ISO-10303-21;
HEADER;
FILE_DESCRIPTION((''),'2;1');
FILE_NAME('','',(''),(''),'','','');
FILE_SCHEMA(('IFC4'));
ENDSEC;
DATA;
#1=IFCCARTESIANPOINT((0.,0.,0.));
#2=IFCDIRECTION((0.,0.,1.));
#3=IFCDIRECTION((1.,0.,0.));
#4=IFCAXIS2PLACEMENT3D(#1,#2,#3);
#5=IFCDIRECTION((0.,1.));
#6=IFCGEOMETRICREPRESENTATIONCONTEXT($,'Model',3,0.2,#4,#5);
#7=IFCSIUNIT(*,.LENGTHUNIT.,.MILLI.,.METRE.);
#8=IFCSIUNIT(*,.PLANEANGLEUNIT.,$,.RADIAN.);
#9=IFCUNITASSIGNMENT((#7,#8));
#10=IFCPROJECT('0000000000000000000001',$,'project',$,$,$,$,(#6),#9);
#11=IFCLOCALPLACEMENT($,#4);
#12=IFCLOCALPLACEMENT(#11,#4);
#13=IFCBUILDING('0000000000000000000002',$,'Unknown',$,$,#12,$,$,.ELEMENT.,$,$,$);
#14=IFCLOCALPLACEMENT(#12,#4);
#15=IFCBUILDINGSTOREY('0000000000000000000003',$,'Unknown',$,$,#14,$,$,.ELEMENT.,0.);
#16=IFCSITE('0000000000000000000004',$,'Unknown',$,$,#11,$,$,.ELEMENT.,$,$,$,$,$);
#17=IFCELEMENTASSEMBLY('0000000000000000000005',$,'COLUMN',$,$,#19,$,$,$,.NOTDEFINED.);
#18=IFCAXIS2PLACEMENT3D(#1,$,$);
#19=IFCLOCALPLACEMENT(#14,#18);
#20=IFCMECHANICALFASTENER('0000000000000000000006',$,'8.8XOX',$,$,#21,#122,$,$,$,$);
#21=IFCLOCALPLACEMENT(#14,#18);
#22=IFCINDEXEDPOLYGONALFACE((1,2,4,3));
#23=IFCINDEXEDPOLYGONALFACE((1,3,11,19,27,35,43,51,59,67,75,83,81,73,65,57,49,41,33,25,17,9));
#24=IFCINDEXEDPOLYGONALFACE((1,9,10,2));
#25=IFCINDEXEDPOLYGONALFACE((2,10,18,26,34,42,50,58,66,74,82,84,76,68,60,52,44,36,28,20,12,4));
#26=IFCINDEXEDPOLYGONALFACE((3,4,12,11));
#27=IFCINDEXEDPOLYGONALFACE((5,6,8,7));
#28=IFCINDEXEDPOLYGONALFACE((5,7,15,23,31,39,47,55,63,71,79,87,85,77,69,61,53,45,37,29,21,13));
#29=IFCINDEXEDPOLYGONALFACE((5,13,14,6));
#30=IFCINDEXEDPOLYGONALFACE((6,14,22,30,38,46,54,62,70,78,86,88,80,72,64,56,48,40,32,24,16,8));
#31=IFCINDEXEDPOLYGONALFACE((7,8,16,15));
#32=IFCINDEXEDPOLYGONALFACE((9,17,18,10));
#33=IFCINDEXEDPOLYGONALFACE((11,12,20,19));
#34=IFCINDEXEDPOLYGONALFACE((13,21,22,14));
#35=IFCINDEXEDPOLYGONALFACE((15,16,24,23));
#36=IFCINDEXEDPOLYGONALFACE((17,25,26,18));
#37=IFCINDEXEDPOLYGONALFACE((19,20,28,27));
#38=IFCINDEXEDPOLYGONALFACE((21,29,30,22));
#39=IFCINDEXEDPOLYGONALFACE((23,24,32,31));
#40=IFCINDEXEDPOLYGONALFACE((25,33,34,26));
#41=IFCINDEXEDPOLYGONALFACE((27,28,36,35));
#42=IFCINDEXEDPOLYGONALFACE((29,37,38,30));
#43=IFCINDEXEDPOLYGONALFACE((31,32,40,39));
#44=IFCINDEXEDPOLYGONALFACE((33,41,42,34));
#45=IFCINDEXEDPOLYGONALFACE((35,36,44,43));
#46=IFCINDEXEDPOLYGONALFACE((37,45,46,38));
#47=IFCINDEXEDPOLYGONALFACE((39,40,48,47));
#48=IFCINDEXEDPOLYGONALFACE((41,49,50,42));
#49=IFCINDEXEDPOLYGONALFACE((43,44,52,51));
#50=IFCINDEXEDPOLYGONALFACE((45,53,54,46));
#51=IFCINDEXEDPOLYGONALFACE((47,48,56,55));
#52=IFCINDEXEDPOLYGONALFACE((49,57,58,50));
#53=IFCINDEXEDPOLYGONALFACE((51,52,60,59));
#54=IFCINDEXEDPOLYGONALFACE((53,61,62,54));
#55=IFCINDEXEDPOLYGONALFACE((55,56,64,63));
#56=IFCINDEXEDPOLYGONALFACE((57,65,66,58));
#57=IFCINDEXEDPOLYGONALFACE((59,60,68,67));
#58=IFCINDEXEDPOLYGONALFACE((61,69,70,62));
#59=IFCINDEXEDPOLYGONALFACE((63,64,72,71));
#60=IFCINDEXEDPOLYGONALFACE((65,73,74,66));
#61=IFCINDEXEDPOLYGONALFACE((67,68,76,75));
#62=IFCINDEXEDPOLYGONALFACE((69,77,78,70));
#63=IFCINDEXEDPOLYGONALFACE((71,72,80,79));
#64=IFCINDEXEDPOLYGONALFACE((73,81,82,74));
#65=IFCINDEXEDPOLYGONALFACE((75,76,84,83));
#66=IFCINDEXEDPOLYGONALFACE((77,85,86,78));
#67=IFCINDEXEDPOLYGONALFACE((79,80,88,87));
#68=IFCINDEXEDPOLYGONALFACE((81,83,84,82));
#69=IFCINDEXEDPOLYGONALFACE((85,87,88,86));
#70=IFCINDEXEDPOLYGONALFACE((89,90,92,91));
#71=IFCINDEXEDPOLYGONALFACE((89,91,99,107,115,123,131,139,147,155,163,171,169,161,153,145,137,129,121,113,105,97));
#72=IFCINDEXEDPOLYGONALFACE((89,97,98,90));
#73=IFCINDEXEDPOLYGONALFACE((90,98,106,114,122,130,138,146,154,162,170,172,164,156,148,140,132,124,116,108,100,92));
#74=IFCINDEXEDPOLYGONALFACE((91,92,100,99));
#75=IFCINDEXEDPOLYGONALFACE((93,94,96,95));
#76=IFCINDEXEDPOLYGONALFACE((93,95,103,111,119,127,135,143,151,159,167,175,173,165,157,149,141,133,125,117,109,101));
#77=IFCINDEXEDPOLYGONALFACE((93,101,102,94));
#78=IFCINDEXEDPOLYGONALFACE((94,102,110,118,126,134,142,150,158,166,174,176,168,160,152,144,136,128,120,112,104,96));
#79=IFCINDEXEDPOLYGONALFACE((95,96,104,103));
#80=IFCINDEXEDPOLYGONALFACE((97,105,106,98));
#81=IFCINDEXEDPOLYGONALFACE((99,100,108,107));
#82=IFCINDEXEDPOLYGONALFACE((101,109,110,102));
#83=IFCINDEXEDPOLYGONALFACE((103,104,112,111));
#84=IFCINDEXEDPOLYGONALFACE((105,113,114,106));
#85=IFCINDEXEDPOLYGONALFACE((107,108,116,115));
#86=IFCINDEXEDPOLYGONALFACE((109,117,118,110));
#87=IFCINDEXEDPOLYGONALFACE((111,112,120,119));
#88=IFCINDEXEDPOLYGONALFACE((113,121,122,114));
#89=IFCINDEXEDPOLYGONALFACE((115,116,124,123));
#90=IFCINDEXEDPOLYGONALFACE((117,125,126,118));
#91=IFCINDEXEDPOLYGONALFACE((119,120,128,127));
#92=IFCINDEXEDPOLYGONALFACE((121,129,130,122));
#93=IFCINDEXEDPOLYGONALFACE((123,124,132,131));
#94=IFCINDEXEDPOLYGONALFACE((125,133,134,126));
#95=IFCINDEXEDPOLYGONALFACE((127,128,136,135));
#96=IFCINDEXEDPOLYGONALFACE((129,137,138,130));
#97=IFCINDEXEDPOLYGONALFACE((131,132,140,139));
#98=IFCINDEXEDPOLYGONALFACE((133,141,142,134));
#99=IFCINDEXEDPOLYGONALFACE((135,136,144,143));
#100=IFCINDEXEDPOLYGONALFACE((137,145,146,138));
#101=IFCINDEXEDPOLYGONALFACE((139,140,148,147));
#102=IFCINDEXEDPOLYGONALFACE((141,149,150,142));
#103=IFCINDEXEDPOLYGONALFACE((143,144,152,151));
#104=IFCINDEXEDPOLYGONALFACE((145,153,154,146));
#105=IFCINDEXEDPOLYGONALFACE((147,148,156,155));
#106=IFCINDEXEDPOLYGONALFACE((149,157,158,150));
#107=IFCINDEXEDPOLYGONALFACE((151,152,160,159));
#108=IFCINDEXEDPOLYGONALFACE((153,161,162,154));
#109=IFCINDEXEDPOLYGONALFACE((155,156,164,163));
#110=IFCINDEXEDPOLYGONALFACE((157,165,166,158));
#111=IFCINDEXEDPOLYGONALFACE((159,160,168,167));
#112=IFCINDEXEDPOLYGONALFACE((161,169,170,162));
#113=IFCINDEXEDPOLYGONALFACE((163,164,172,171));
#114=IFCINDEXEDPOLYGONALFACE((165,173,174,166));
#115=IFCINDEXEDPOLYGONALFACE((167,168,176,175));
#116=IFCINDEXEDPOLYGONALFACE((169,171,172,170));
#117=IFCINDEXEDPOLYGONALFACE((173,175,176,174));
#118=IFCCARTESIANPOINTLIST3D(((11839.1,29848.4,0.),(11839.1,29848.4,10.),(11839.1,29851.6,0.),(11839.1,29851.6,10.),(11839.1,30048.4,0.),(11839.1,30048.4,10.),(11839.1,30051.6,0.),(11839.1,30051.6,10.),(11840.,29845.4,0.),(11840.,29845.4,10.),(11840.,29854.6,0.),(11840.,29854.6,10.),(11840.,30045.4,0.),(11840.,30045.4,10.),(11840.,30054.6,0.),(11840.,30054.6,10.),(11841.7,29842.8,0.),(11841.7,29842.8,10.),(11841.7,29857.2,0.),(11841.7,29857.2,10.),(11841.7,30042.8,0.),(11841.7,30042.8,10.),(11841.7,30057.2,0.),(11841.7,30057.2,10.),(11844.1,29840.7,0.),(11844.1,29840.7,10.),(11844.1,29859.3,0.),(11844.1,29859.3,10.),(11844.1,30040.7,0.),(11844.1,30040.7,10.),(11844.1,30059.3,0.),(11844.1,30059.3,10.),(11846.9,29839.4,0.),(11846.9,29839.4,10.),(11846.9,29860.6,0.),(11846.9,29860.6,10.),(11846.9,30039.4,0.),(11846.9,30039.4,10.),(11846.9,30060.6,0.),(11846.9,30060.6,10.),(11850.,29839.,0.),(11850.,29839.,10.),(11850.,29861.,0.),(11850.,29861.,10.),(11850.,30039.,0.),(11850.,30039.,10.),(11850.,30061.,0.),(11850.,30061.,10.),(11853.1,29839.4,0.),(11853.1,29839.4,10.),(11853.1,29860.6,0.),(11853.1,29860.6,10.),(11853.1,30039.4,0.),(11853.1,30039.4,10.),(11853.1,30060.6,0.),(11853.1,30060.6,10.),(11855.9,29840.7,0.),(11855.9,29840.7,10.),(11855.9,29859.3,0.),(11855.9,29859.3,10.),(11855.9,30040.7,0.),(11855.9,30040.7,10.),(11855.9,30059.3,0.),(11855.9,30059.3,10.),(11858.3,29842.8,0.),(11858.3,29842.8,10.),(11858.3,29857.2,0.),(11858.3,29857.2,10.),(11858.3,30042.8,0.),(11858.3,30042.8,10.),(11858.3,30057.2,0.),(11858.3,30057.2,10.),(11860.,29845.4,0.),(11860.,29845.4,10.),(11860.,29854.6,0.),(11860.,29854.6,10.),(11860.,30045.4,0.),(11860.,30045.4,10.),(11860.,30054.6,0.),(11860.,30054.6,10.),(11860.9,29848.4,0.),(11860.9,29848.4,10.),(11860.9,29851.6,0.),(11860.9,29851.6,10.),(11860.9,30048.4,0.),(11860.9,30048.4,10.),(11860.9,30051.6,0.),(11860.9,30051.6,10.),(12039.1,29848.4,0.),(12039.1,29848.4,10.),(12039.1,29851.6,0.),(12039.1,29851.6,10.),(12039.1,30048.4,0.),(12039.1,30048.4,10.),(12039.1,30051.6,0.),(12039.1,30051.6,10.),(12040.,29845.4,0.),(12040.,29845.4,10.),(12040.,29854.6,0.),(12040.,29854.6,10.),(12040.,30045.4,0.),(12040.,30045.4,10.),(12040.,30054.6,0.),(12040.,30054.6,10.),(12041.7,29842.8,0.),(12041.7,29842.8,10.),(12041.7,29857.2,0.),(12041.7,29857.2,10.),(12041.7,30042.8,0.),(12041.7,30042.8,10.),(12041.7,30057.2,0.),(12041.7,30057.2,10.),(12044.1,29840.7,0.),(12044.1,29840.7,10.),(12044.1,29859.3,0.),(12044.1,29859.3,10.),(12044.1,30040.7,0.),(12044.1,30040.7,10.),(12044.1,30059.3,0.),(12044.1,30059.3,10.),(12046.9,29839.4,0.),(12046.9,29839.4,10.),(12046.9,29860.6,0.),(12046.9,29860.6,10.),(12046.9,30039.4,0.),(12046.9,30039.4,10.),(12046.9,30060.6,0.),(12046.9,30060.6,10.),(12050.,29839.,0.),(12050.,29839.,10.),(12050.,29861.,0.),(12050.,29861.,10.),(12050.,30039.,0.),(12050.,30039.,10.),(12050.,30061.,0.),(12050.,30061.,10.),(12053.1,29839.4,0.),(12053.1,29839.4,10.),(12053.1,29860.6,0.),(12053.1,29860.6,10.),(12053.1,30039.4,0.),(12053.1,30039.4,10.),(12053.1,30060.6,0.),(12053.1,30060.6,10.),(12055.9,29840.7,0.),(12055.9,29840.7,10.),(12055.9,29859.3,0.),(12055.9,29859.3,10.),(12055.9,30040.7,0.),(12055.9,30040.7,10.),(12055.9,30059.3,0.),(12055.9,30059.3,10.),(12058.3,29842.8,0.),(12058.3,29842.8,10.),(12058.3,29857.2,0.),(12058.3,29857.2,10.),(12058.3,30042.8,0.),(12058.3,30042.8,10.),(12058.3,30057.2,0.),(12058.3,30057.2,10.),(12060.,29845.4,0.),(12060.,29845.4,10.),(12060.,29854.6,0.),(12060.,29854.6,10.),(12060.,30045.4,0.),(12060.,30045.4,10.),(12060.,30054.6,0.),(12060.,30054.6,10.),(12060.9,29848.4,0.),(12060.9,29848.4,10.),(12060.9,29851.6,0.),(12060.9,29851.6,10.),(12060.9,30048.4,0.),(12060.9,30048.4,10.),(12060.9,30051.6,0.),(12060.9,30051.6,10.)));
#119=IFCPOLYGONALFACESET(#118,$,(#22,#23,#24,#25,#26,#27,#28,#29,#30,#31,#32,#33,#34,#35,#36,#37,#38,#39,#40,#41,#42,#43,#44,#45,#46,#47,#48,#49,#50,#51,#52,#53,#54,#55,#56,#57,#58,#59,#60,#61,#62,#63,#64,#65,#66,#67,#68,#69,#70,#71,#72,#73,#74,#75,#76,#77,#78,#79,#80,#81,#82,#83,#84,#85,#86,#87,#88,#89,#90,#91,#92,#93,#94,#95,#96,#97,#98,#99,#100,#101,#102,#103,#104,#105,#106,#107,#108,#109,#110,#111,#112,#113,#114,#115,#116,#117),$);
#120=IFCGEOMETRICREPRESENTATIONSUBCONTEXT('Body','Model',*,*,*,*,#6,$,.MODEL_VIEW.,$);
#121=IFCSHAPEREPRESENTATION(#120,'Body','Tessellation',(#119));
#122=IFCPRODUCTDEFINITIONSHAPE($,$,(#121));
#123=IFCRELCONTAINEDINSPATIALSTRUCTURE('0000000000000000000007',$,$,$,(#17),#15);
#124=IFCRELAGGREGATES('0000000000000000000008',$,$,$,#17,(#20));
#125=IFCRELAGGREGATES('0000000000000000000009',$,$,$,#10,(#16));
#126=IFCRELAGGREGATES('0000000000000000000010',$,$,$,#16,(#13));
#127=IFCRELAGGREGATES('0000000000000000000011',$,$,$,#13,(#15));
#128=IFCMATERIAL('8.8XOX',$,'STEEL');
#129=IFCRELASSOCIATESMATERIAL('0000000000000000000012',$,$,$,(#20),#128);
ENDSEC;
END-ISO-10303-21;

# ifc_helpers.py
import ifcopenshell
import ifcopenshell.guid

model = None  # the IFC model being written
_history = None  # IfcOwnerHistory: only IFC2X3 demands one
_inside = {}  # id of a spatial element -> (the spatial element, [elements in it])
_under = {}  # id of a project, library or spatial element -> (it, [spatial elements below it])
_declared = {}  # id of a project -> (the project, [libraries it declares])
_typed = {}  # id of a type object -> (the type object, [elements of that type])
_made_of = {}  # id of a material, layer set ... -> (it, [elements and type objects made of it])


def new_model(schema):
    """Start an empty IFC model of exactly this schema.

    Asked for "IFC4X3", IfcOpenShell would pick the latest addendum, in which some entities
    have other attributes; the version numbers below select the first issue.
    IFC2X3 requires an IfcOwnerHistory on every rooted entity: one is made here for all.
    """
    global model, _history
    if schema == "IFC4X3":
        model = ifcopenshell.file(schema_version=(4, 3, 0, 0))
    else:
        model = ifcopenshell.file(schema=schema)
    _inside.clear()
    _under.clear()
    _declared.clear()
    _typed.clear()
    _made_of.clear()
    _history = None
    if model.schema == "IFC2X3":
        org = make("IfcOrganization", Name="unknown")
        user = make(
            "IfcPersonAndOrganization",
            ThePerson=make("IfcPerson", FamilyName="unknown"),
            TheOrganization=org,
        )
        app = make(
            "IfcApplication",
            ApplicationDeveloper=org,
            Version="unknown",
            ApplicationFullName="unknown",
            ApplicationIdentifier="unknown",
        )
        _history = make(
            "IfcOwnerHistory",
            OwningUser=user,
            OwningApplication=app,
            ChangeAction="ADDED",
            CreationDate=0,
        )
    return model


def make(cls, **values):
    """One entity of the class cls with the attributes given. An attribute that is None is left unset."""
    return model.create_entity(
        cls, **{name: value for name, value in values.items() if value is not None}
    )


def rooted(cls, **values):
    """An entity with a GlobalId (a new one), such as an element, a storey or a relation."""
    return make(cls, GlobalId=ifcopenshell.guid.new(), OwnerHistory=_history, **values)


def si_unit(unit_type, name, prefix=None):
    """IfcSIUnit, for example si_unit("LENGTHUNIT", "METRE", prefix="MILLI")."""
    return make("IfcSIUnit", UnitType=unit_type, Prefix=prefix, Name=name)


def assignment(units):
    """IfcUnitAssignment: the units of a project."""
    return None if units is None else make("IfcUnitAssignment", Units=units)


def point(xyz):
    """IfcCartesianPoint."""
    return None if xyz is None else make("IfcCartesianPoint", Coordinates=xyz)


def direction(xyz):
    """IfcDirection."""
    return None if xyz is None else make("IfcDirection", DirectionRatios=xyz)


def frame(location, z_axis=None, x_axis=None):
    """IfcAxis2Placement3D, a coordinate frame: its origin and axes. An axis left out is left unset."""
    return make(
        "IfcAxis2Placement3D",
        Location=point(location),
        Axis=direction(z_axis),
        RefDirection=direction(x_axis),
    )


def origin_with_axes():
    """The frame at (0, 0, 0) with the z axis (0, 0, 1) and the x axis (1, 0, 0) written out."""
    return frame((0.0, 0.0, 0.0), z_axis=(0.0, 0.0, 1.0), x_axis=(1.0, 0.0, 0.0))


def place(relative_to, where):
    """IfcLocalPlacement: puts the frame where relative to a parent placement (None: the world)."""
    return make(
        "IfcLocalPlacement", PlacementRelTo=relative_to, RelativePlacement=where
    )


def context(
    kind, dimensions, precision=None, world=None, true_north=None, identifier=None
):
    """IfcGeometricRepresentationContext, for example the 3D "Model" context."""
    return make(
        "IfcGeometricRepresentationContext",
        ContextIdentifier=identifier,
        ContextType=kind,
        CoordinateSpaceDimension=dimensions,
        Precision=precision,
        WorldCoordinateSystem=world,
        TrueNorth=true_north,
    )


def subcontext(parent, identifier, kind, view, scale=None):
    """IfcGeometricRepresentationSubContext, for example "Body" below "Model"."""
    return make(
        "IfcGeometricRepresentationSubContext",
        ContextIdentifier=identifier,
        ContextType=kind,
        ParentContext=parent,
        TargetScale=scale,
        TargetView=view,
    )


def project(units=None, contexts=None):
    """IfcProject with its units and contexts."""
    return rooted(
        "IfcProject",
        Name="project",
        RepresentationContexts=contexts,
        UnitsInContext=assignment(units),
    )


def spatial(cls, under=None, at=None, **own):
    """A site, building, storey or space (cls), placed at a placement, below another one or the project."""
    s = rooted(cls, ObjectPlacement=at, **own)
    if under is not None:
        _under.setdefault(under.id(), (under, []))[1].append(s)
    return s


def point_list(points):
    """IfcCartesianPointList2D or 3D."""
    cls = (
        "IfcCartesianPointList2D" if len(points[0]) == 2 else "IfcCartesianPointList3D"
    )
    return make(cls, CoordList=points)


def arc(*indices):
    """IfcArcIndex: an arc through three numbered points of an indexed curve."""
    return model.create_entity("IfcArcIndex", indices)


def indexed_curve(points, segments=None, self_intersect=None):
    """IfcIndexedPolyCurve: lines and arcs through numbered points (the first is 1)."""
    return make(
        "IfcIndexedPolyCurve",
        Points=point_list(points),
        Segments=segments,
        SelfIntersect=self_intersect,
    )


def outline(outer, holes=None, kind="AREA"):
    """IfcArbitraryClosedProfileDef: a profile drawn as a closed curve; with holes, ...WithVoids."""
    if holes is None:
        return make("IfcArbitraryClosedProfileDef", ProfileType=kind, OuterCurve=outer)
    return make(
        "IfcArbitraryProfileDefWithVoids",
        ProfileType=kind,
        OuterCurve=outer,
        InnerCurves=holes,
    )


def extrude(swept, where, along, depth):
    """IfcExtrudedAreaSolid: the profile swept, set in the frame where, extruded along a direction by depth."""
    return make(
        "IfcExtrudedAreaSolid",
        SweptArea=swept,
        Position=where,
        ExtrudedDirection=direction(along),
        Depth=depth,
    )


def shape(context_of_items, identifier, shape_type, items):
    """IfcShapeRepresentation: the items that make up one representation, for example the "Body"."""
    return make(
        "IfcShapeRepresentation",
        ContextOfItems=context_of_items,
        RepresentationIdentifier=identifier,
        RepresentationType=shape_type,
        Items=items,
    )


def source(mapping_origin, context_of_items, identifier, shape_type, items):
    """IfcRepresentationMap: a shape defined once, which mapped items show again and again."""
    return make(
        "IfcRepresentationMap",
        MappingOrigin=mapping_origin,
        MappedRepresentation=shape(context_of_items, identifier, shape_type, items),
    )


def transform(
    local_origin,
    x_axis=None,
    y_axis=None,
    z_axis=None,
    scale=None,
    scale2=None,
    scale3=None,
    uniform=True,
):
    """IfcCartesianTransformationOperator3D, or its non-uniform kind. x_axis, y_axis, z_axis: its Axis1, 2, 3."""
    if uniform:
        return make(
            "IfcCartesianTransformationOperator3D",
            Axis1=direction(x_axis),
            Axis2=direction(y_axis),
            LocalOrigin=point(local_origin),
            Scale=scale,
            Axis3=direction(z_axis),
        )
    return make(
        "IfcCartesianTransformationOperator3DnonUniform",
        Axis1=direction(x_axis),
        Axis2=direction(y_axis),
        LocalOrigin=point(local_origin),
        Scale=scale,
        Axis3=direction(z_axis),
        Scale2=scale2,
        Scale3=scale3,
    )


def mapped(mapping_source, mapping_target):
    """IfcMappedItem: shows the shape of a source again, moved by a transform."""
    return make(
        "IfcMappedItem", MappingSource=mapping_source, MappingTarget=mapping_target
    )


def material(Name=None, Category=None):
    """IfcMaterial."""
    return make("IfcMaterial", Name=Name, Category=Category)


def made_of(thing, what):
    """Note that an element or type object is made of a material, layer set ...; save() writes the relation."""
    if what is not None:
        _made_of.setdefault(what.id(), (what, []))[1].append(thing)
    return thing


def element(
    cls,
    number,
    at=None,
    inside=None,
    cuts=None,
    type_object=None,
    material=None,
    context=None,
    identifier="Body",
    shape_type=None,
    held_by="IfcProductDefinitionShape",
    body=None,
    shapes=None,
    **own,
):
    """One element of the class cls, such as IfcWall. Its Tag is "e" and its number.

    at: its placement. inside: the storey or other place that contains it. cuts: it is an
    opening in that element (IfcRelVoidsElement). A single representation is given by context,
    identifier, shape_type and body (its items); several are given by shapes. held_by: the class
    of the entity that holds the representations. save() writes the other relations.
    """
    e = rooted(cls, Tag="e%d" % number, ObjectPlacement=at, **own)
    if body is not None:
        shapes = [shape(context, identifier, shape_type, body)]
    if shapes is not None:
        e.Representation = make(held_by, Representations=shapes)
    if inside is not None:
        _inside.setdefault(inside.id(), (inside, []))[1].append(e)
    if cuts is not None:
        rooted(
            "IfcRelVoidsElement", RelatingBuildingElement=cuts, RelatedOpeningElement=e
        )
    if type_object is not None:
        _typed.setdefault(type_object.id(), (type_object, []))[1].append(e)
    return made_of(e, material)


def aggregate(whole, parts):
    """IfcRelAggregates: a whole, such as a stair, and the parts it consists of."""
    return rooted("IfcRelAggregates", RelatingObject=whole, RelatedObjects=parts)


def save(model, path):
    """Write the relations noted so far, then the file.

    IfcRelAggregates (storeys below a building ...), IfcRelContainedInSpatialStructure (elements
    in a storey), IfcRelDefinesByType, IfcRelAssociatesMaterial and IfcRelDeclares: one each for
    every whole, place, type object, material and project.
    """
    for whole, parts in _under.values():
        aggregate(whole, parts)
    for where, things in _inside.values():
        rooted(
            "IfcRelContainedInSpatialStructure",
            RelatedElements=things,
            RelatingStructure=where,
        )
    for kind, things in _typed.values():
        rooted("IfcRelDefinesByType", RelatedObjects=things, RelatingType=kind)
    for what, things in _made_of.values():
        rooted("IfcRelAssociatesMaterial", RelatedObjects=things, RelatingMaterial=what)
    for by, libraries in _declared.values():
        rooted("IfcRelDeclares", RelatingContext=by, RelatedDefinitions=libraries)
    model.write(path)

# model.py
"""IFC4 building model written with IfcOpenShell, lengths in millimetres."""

from ifc_helpers import new_model, si_unit, direction, frame, origin_with_axes, place, context, subcontext, project, spatial, arc, indexed_curve, outline, extrude, source, transform, mapped, material, element, aggregate, save


model = new_model("IFC4")

# Units and contexts
model_context = context("Model", 3, precision=0.2, world=origin_with_axes(), true_north=direction((0.0, 1.0)))
body_context = subcontext(model_context, "Body", "Model", "MODEL_VIEW")
ifc_project = project(units=[si_unit("LENGTHUNIT", "METRE", prefix="MILLI"), si_unit("PLANEANGLEUNIT", "RADIAN")], contexts=[model_context])

# Site, building, storey
site_placement = place(None, origin_with_axes())
site = spatial("IfcSite", under=ifc_project, at=site_placement, Name="Unknown", CompositionType="ELEMENT")
building_placement = place(site_placement, origin_with_axes())
building = spatial("IfcBuilding", under=site, at=building_placement, Name="Unknown", CompositionType="ELEMENT")
storey_placement = place(building_placement, origin_with_axes())
storey = spatial("IfcBuildingStorey", under=building, at=storey_placement, Name="Unknown", CompositionType="ELEMENT", Elevation=0.0)

# Element assembly
assembly_1_placement = place(storey_placement, frame((11950.0, 29950.0, 0.0), z_axis=(0.0, 1.0, 0.0), x_axis=(0.0, 0.0, 1.0)))
assembly_1 = element("IfcElementAssembly", 1, at=assembly_1_placement, inside=storey, Name="COLUMN", PredefinedType="NOTDEFINED")

# Mechanical fastener
ifc_material_1 = material(Name="8.8XOX", Category="STEEL")
shared_shape_1 = source(origin_with_axes(), body_context, "Body", "SweptSolid", [
    extrude(outline(indexed_curve([(11.0, 0.0), (0.0, 11.0), (-11.0, 0.0), (0.0, -11.0)], segments=[arc(1, 2, 3), arc(3, 4, 1)])), frame((0.0, 0.0, 0.0), z_axis=(0.0, 0.0, -1.0), x_axis=(0.0, 1.0, 0.0)), (0.0, 0.0, 1.0), 10.0),
])
mechanical_fastener_1_placement = place(assembly_1_placement, frame((10.0, 50.0, 0.0), z_axis=(1.0, 0.0, 0.0), x_axis=(0.0, -1.0, 0.0)))
mechanical_fastener_1 = element("IfcMechanicalFastener", 2, at=mechanical_fastener_1_placement, material=ifc_material_1, Name="8.8XOX", context=body_context, shape_type="MappedRepresentation", body=[
    mapped(shared_shape_1, transform((-50.0, 100.0, 0.0))),
    mapped(shared_shape_1, transform((-50.0, -100.0, 0.0))),
    mapped(shared_shape_1, transform((150.0, 100.0, 0.0))),
    mapped(shared_shape_1, transform((150.0, -100.0, 0.0))),
])

aggregate(assembly_1, [mechanical_fastener_1])

save(model, "model.ifc")
